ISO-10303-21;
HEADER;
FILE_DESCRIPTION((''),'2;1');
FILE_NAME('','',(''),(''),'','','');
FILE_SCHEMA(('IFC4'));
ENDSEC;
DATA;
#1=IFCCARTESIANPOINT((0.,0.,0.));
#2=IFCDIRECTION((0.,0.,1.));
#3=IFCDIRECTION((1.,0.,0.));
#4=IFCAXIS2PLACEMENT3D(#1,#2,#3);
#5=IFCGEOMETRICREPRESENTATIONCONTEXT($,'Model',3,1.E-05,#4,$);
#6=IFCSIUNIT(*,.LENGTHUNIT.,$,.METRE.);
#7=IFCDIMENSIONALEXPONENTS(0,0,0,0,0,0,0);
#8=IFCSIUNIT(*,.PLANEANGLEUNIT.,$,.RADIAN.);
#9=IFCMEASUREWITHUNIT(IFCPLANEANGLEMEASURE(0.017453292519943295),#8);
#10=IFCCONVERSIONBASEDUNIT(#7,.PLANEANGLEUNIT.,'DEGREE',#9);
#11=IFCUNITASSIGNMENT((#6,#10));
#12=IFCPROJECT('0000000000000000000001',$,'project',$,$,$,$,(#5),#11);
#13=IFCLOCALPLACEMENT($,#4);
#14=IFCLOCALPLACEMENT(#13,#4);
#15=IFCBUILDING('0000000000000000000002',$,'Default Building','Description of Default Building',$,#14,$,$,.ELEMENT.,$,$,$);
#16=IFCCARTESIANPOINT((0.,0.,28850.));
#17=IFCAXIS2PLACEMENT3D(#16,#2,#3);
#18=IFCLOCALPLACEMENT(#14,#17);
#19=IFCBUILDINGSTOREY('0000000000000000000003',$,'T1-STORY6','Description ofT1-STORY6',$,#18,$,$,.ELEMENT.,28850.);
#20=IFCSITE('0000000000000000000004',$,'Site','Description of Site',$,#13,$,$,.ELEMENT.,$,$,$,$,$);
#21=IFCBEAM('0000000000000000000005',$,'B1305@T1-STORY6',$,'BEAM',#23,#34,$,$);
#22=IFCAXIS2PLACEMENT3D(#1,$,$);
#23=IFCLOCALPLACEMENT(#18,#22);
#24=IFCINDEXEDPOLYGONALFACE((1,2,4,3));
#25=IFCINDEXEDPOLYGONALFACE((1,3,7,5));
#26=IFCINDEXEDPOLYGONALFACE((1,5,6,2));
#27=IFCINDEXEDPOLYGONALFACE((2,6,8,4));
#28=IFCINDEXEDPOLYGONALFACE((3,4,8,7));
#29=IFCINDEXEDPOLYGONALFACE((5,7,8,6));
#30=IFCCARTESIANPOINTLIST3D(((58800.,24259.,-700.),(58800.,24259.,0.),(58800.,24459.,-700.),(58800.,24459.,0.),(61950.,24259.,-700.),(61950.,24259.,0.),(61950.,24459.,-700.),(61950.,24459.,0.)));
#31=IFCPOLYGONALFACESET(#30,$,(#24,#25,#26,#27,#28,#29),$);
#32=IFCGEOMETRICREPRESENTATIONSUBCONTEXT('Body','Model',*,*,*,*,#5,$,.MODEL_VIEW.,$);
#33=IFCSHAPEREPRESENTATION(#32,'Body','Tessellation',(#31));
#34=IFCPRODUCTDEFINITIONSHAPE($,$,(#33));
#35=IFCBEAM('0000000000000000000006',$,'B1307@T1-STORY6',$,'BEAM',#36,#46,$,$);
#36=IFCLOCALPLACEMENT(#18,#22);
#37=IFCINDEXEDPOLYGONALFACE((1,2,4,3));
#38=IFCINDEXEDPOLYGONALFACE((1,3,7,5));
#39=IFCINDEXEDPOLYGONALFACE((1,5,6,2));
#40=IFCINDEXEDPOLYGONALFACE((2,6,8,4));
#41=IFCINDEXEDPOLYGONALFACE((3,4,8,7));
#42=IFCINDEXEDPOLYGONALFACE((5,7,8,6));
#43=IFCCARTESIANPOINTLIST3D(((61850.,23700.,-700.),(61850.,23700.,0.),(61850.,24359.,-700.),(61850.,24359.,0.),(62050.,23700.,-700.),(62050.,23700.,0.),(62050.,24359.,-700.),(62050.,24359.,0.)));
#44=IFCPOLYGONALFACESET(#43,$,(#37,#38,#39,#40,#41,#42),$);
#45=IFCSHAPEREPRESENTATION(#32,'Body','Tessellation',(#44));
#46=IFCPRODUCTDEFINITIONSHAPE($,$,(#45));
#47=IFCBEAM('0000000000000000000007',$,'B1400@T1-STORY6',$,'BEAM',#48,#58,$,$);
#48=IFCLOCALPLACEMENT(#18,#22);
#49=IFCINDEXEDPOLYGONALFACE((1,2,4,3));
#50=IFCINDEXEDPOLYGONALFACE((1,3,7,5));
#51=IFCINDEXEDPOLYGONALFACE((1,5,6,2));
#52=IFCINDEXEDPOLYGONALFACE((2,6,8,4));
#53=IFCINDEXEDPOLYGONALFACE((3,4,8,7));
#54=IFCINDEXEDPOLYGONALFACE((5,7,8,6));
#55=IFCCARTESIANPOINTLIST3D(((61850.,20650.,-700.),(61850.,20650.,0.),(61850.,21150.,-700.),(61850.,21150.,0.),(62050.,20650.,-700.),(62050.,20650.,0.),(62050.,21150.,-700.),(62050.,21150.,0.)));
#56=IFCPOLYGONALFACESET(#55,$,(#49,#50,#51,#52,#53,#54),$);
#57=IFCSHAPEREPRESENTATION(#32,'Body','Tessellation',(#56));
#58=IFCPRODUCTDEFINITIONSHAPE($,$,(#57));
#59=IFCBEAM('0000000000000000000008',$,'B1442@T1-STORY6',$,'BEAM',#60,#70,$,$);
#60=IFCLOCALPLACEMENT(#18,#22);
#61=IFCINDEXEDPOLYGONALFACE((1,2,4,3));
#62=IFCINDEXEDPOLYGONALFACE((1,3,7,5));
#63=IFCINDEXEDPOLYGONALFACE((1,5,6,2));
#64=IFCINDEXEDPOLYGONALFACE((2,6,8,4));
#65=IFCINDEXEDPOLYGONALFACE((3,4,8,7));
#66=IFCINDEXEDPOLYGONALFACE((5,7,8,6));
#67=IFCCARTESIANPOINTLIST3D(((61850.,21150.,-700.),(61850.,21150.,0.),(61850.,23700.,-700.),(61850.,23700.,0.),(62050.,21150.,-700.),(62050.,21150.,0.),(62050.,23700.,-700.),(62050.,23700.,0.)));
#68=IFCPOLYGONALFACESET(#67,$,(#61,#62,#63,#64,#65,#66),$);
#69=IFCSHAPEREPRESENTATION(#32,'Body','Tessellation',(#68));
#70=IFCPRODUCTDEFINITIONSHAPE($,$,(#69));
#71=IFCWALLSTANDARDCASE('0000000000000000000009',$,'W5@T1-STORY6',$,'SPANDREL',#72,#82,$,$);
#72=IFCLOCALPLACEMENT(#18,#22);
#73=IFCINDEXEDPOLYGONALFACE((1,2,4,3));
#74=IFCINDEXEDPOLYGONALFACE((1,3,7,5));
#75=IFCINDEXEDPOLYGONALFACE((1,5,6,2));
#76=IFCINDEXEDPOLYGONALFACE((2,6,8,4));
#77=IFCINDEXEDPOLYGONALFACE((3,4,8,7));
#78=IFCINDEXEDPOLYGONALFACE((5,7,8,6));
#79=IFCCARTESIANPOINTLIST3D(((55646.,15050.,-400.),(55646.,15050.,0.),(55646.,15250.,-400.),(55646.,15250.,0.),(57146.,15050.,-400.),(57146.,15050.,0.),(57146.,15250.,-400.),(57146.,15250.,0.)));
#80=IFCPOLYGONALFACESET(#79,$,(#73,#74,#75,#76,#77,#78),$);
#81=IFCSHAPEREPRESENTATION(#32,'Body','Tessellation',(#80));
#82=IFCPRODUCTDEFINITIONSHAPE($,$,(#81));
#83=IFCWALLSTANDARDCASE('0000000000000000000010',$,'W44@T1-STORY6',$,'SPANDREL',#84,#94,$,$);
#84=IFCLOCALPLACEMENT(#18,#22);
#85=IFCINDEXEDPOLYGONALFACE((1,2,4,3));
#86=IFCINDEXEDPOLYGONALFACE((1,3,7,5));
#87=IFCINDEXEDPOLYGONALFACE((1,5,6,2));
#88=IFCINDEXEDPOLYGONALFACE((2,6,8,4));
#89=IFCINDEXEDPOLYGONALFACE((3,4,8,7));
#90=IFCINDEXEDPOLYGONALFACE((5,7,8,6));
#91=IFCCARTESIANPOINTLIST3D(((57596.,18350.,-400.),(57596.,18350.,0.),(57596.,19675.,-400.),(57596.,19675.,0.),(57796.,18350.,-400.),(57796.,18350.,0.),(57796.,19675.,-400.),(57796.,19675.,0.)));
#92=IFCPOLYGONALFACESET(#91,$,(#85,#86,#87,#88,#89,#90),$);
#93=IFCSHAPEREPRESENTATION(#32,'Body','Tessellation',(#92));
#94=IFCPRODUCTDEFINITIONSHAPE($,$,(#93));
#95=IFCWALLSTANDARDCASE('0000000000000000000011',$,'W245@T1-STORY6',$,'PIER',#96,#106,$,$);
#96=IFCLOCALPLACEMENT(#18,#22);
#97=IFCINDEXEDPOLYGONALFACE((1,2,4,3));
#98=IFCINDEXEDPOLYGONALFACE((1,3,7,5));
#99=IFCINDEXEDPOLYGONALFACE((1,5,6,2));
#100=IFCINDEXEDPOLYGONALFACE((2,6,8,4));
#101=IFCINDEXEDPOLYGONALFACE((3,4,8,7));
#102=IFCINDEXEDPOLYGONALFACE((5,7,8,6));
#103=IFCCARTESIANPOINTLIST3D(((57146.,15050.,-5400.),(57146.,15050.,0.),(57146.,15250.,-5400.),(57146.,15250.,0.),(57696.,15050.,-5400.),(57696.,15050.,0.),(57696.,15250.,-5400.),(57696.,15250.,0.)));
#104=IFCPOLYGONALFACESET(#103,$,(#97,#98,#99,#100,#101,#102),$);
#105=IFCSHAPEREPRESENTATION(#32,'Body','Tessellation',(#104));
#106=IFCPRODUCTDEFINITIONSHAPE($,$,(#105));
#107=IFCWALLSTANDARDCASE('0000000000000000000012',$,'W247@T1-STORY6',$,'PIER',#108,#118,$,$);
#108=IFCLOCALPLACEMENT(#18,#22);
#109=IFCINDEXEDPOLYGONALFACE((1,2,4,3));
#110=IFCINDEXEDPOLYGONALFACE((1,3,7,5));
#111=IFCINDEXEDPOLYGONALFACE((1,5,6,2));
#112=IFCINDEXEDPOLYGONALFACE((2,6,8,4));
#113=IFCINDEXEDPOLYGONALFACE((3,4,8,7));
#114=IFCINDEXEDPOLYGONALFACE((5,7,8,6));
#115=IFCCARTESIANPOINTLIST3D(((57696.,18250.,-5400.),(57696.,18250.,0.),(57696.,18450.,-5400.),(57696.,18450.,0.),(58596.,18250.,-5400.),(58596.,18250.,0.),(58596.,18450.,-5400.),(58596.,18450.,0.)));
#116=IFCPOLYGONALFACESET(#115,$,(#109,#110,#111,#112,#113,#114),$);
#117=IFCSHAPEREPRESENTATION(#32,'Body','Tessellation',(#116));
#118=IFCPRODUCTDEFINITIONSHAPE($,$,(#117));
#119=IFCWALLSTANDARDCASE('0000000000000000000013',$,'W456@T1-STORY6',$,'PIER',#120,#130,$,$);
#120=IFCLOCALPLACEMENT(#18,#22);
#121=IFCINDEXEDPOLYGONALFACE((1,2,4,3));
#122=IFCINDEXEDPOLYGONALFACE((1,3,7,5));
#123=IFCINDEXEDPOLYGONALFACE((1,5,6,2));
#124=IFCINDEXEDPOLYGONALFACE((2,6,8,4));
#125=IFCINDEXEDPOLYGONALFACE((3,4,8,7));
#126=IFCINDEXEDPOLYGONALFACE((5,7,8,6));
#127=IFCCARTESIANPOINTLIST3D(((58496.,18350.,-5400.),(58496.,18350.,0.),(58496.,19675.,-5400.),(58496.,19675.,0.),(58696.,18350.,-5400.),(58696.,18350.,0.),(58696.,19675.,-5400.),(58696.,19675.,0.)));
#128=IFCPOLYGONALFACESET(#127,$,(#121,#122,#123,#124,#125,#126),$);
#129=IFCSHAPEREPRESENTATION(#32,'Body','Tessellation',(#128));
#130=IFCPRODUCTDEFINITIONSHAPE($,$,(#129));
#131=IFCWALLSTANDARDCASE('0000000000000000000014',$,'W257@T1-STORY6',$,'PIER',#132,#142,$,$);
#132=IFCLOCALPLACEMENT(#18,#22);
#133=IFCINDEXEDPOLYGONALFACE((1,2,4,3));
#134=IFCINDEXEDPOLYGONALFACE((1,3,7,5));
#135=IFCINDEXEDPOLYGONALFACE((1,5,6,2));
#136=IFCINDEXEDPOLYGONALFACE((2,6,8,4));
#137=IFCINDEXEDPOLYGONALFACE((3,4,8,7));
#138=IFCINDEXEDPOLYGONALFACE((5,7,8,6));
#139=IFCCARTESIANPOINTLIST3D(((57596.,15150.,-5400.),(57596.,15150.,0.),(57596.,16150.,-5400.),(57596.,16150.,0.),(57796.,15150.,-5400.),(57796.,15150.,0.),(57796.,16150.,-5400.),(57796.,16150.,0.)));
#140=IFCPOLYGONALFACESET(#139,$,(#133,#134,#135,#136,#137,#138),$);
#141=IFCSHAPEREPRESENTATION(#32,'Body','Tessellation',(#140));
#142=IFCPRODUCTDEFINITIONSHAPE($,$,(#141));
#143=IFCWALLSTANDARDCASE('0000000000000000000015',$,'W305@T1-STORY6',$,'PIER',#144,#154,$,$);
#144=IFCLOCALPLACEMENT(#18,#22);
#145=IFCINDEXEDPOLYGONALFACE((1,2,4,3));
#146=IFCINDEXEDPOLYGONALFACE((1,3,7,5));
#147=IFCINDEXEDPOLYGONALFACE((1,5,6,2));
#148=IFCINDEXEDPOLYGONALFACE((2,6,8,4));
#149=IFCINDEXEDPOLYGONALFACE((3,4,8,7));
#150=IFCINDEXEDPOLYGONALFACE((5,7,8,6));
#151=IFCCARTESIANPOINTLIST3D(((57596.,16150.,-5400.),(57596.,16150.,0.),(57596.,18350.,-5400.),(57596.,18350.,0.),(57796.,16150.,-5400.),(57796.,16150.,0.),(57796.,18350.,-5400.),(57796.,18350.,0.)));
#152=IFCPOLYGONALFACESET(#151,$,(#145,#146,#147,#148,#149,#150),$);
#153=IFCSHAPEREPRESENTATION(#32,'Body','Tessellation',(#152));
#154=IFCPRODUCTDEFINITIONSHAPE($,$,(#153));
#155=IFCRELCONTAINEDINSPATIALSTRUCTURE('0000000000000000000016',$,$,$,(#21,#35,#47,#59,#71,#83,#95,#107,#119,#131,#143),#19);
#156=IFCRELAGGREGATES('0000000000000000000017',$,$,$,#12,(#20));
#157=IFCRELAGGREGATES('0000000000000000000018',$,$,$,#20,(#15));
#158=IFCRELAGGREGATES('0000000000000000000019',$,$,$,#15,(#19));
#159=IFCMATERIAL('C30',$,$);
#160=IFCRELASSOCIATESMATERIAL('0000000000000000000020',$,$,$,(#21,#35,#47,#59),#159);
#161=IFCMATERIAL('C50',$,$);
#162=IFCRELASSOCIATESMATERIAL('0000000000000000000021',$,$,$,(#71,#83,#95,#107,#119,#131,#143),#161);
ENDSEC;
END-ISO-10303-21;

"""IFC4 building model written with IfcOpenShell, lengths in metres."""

from ifc_helpers import new_model, entity, si_unit, converted_unit, frame, origin_with_axes, place, context, subcontext, project, spatial, indexed_curve, rectangle, outline, extrude, material, element, save


model = new_model("IFC4")

# Units and contexts
model_context = context("Model", 3, precision=1e-05, world=origin_with_axes())
body_context = subcontext(model_context, "Body", "Model", "MODEL_VIEW")
ifc_project = project(units=[si_unit("LENGTHUNIT", "METRE"), converted_unit("PLANEANGLEUNIT", "DEGREE", entity("IfcPlaneAngleMeasure", 0.017453292519943295), si_unit("PLANEANGLEUNIT", "RADIAN"), dimensions=[0, 0, 0, 0, 0, 0, 0])], contexts=[model_context])

# Site, building, storey
site_placement = place(None, origin_with_axes())
site = spatial("IfcSite", under=ifc_project, at=site_placement, Name="Site", Description="Description of Site", CompositionType="ELEMENT")
building_placement = place(site_placement, origin_with_axes())
building = spatial("IfcBuilding", under=site, at=building_placement, Name="Default Building", Description="Description of Default Building", CompositionType="ELEMENT")
storey_placement = place(building_placement, frame((0.0, 0.0, 28850.0), z_axis=(0.0, 0.0, 1.0), x_axis=(1.0, 0.0, 0.0)))
storey = spatial("IfcBuildingStorey", under=building, at=storey_placement, Name="T1-STORY6", Description="Description ofT1-STORY6", CompositionType="ELEMENT", Elevation=28850.0)

# Beams
ifc_material_1 = material(Name="C30")
beam_1_placement = place(storey_placement, frame((58800.0, 24359.0, -350.0), z_axis=(1.0, 0.0, 0.0), x_axis=(0.0, 1.0, 0.0)))
element("IfcBeam", 1, at=beam_1_placement, inside=storey, material=ifc_material_1, Name="B1305@T1-STORY6", ObjectType="BEAM", context=body_context, shape_type="SweptSolid", body=[
    extrude(rectangle(XDim=200.0, YDim=700.0), origin_with_axes(), (0.0, 0.0, 1.0), 3150.0),
])
beam_2_placement = place(storey_placement, frame((61950.0, 23700.0, -350.0), z_axis=(0.0, 1.0, 0.0), x_axis=(-1.0, 0.0, 0.0)))
element("IfcBeam", 2, at=beam_2_placement, inside=storey, material=ifc_material_1, Name="B1307@T1-STORY6", ObjectType="BEAM", context=body_context, shape_type="SweptSolid", body=[
    extrude(rectangle(XDim=200.0, YDim=700.0), origin_with_axes(), (0.0, 0.0, 1.0), 659.0),
])
beam_3_placement = place(storey_placement, frame((61950.0, 20650.0, -350.0), z_axis=(0.0, 1.0, 0.0), x_axis=(-1.0, 0.0, 0.0)))
element("IfcBeam", 3, at=beam_3_placement, inside=storey, material=ifc_material_1, Name="B1400@T1-STORY6", ObjectType="BEAM", context=body_context, shape_type="SweptSolid", body=[
    extrude(rectangle(XDim=200.0, YDim=700.0), origin_with_axes(), (0.0, 0.0, 1.0), 500.0),
])
beam_4_placement = place(storey_placement, frame((61950.0, 21150.0, -350.0), z_axis=(0.0, 1.0, 0.0), x_axis=(-1.0, 0.0, 0.0)))
element("IfcBeam", 4, at=beam_4_placement, inside=storey, material=ifc_material_1, Name="B1442@T1-STORY6", ObjectType="BEAM", context=body_context, shape_type="SweptSolid", body=[
    extrude(rectangle(XDim=200.0, YDim=700.0), origin_with_axes(), (0.0, 0.0, 1.0), 2550.0),
])
ifc_material_2 = material(Name="C50")

# Walls
wall_1_placement = place(storey_placement, frame((55646.0, 15150.0, -400.0), z_axis=(0.0, 0.0, 1.0), x_axis=(1.0, 0.0, 0.0)))
element("IfcWallStandardCase", 5, at=wall_1_placement, inside=storey, material=ifc_material_2, Name="W5@T1-STORY6", ObjectType="SPANDREL", context=body_context, shape_type="SweptSolid", body=[
    extrude(outline(indexed_curve([(0.0, -100.0), (0.0, 100.0), (1500.0, 100.0), (1500.0, -100.0), (0.0, -100.0)], self_intersect=False)), origin_with_axes(), (0.0, 0.0, 1.0), 400.0),
])
wall_2_placement = place(storey_placement, frame((57696.0, 18350.0, -400.0), z_axis=(0.0, 0.0, 1.0), x_axis=(0.0, 1.0, 0.0)))
element("IfcWallStandardCase", 6, at=wall_2_placement, inside=storey, material=ifc_material_2, Name="W44@T1-STORY6", ObjectType="SPANDREL", context=body_context, shape_type="SweptSolid", body=[
    extrude(outline(indexed_curve([(0.0, -100.0), (0.0, 100.0), (1325.0, 100.0), (1325.0, -100.0), (0.0, -100.0)], self_intersect=False)), origin_with_axes(), (0.0, 0.0, 1.0), 400.0),
])
wall_3_placement = place(storey_placement, frame((57146.0, 15150.0, -5400.0), z_axis=(0.0, 0.0, 1.0), x_axis=(1.0, 0.0, 0.0)))
element("IfcWallStandardCase", 7, at=wall_3_placement, inside=storey, material=ifc_material_2, Name="W245@T1-STORY6", ObjectType="PIER", context=body_context, shape_type="SweptSolid", body=[
    extrude(outline(indexed_curve([(0.0, -100.0), (0.0, 100.0), (550.0, 100.0), (550.0, -100.0), (0.0, -100.0)], self_intersect=False)), origin_with_axes(), (0.0, 0.0, 1.0), 5400.0),
])
wall_4_placement = place(storey_placement, frame((57696.0, 18350.0, -5400.0), z_axis=(0.0, 0.0, 1.0), x_axis=(1.0, 0.0, 0.0)))
element("IfcWallStandardCase", 8, at=wall_4_placement, inside=storey, material=ifc_material_2, Name="W247@T1-STORY6", ObjectType="PIER", context=body_context, shape_type="SweptSolid", body=[
    extrude(outline(indexed_curve([(0.0, -100.0), (0.0, 100.0), (900.0, 100.0), (900.0, -100.0), (0.0, -100.0)], self_intersect=False)), origin_with_axes(), (0.0, 0.0, 1.0), 5400.0),
])
wall_5_placement = place(storey_placement, frame((58596.0, 18350.0, -5400.0), z_axis=(0.0, 0.0, 1.0), x_axis=(0.0, 1.0, 0.0)))
element("IfcWallStandardCase", 9, at=wall_5_placement, inside=storey, material=ifc_material_2, Name="W456@T1-STORY6", ObjectType="PIER", context=body_context, shape_type="SweptSolid", body=[
    extrude(outline(indexed_curve([(0.0, -100.0), (0.0, 100.0), (1325.0, 100.0), (1325.0, -100.0), (0.0, -100.0)], self_intersect=False)), origin_with_axes(), (0.0, 0.0, 1.0), 5400.0),
])
wall_6_placement = place(storey_placement, frame((57696.0, 15150.0, -5400.0), z_axis=(0.0, 0.0, 1.0), x_axis=(0.0, 1.0, 0.0)))
element("IfcWallStandardCase", 10, at=wall_6_placement, inside=storey, material=ifc_material_2, Name="W257@T1-STORY6", ObjectType="PIER", context=body_context, shape_type="SweptSolid", body=[
    extrude(outline(indexed_curve([(0.0, -100.0), (0.0, 100.0), (1000.0, 100.0), (1000.0, -100.0), (0.0, -100.0)], self_intersect=False)), origin_with_axes(), (0.0, 0.0, 1.0), 5400.0),
])
wall_7_placement = place(storey_placement, frame((57696.0, 16150.0, -5400.0), z_axis=(0.0, 0.0, 1.0), x_axis=(0.0, 1.0, 0.0)))
element("IfcWallStandardCase", 11, at=wall_7_placement, inside=storey, material=ifc_material_2, Name="W305@T1-STORY6", ObjectType="PIER", context=body_context, shape_type="SweptSolid", body=[
    extrude(outline(indexed_curve([(0.0, -100.0), (0.0, 100.0), (2200.0, 100.0), (2200.0, -100.0), (0.0, -100.0)], self_intersect=False)), origin_with_axes(), (0.0, 0.0, 1.0), 5400.0),
])

save(model, "model.ifc")
